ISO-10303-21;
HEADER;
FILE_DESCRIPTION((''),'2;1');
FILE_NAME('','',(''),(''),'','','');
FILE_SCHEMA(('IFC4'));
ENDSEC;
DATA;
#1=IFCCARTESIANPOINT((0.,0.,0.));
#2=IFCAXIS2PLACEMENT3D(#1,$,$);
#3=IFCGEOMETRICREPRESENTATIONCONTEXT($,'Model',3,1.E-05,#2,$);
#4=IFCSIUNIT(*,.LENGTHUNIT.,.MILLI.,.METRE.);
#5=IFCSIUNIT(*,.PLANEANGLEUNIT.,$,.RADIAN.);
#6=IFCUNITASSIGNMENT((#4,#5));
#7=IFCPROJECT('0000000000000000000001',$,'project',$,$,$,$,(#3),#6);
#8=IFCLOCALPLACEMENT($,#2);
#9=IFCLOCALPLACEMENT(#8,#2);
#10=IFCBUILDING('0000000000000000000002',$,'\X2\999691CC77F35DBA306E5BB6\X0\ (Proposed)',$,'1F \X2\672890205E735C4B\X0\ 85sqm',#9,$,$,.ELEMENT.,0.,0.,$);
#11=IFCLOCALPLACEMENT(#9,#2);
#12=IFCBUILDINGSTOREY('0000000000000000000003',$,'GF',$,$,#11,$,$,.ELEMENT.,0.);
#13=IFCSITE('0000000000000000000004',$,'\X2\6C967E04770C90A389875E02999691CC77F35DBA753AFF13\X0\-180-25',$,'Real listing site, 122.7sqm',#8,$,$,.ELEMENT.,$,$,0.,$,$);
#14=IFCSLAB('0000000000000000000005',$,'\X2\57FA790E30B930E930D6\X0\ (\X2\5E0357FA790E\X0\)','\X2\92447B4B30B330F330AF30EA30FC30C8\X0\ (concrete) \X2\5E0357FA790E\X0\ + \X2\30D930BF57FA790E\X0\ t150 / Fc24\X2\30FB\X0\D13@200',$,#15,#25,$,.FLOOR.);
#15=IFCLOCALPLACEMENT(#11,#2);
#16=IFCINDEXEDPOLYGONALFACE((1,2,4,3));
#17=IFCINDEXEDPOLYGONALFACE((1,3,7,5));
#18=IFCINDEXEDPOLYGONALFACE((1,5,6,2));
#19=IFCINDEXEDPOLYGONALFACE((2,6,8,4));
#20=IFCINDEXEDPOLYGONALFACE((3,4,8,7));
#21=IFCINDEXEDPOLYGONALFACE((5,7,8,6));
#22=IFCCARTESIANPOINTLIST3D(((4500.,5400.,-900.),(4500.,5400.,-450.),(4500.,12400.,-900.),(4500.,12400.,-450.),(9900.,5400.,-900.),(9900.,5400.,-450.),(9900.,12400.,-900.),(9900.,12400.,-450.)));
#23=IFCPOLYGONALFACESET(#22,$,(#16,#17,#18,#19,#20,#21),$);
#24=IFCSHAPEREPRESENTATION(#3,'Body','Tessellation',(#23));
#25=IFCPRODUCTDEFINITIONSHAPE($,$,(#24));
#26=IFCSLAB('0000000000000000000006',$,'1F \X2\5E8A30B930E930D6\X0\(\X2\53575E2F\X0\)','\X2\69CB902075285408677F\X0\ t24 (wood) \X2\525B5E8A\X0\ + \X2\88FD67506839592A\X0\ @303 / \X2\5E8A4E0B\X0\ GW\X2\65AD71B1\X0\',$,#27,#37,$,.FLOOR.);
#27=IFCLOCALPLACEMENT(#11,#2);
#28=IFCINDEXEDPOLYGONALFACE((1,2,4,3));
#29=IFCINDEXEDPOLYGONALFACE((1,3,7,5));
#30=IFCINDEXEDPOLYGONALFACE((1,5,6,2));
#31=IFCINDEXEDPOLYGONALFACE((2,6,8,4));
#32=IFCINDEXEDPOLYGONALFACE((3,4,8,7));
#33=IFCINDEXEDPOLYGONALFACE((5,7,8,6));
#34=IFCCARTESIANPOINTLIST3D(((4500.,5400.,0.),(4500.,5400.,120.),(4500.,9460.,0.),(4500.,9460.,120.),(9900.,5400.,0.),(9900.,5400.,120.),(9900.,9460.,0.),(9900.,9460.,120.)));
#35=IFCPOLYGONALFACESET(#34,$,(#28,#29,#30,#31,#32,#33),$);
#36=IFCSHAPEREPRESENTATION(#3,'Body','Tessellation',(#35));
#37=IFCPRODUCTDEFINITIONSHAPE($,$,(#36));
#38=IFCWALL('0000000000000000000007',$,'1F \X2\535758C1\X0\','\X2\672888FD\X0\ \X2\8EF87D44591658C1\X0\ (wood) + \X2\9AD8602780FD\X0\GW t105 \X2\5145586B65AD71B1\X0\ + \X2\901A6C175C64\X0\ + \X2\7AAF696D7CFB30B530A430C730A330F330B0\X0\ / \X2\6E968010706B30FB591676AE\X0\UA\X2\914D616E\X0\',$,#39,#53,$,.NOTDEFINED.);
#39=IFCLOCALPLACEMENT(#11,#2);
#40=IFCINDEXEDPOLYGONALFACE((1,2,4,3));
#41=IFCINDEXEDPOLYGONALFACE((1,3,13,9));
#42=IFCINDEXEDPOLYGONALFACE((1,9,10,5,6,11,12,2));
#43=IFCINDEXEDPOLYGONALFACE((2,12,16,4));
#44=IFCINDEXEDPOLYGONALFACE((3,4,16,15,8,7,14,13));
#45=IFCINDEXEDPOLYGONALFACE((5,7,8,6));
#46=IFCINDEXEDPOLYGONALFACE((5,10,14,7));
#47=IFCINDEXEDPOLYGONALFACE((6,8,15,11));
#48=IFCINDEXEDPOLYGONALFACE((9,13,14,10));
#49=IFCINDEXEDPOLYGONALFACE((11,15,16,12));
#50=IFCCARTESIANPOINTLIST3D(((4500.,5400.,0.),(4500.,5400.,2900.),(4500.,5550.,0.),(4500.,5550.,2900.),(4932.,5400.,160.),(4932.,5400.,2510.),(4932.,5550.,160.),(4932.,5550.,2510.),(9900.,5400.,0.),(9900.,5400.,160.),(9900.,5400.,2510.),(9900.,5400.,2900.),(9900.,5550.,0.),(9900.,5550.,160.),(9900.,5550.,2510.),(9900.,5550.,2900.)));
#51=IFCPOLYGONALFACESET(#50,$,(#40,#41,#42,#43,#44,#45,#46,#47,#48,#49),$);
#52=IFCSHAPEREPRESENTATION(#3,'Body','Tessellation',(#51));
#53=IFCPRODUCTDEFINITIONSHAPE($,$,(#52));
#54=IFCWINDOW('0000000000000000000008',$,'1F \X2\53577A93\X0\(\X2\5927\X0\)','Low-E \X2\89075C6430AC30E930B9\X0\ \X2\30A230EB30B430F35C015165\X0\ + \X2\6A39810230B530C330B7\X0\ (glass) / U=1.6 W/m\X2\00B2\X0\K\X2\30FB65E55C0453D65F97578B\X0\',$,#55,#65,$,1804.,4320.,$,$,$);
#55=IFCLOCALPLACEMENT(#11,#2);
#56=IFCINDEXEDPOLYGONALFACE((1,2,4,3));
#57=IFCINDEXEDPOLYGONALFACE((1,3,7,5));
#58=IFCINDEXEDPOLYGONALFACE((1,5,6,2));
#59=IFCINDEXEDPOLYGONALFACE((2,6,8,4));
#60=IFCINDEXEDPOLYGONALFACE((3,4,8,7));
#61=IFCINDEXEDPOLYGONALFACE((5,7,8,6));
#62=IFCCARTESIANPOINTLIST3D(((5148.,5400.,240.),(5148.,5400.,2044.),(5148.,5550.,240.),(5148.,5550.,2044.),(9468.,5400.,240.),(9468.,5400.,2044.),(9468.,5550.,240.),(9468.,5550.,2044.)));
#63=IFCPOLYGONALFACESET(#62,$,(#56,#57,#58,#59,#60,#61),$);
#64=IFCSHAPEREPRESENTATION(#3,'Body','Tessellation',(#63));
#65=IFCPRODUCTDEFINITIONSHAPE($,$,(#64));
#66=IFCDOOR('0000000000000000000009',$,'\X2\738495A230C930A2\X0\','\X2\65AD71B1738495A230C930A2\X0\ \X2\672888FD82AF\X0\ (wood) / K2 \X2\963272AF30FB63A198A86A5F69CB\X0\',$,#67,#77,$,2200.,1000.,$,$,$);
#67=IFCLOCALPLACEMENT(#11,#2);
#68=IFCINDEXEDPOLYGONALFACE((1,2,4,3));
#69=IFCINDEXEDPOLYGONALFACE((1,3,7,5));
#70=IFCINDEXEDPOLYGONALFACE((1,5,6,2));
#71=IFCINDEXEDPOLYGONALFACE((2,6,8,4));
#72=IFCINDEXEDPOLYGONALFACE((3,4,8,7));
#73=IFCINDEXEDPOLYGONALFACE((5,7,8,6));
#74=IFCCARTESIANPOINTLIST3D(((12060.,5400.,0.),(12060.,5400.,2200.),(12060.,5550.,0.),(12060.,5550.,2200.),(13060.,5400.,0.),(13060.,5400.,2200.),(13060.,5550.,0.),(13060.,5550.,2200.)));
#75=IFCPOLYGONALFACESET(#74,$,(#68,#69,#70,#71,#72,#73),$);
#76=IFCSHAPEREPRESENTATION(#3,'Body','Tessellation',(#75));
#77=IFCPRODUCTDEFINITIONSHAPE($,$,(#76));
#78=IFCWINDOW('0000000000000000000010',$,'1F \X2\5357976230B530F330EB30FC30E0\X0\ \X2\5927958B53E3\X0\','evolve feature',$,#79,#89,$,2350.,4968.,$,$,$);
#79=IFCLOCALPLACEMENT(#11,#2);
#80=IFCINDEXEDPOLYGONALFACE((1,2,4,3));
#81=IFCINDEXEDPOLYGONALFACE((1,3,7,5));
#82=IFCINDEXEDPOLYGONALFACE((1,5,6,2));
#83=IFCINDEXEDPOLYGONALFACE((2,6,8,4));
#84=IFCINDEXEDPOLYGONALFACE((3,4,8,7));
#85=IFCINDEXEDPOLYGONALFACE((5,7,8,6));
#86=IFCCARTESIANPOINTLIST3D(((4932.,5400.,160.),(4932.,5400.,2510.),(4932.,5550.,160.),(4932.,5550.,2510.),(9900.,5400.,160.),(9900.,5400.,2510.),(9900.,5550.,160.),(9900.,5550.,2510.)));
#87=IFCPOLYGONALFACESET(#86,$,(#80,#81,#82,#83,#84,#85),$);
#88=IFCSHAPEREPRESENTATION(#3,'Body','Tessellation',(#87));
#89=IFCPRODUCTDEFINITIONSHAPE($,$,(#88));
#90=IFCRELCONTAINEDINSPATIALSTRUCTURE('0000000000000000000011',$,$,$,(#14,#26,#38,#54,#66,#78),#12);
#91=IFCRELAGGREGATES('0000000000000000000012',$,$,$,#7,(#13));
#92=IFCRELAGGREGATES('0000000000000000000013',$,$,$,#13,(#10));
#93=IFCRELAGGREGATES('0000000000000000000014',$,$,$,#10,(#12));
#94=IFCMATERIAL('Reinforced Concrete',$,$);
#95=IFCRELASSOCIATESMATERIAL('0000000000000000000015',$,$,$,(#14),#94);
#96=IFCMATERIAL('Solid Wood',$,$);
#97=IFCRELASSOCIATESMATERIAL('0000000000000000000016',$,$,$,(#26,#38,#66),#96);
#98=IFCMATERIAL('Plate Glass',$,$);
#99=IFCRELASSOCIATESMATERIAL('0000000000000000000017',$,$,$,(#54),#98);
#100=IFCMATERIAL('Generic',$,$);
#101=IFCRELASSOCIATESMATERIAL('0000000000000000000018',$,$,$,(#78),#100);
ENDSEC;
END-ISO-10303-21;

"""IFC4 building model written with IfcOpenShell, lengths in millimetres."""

from ifc_helpers import new_model, si_unit, frame, frame_2d, origin, place, context, project, spatial, rectangle, extrude, material, element, fill, save


model = new_model("IFC4")

# Units and contexts
model_context = context("Model", 3, precision=1e-05, world=origin())
ifc_project = project(units=[si_unit("LENGTHUNIT", "METRE", prefix="MILLI"), si_unit("PLANEANGLEUNIT", "RADIAN")], contexts=[model_context])

# Site, building, storey
site_placement = place(None, origin())
site = spatial("IfcSite", under=ifc_project, at=site_placement, Name="沖縄県那覇市首里石嶺町３-180-25", ObjectType="Real listing site, 122.7sqm", CompositionType="ELEMENT", RefElevation=0.0)
building_placement = place(site_placement, origin())
building = spatial("IfcBuilding", under=site, at=building_placement, Name="首里石嶺の家 (Proposed)", ObjectType="1F 木造平屋 85sqm", CompositionType="ELEMENT", ElevationOfRefHeight=0.0, ElevationOfTerrain=0.0)
storey_placement = place(building_placement, origin())
storey = spatial("IfcBuildingStorey", under=building, at=storey_placement, Name="GF", CompositionType="ELEMENT", Elevation=0.0)

# Slabs
ifc_material_1 = material(Name="Reinforced Concrete")
slab_1_placement = place(storey_placement, frame((2250.0, 2700.0, -450.0)))
element("IfcSlab", 1, at=slab_1_placement, inside=storey, material=ifc_material_1, Name="基礎スラブ (布基礎)", Description="鉄筋コンクリート (concrete) 布基礎 + ベタ基礎 t150 / Fc24・D13@200", PredefinedType="FLOOR", context=model_context, shape_type="SweptSolid", body=[
    extrude(rectangle(XDim=5400.0, YDim=7000.0, at=frame_2d((2700.0, 3500.0))), frame((2250.0, 2700.0, -450.0)), (0.0, 0.0, 1.0), 450.0),
])
ifc_material_2 = material(Name="Solid Wood")
slab_2_placement = place(storey_placement, frame((2250.0, 2700.0, 0.0)))
element("IfcSlab", 2, at=slab_2_placement, inside=storey, material=ifc_material_2, Name="1F 床スラブ(南帯)", Description="構造用合板 t24 (wood) 剛床 + 製材根太 @303 / 床下 GW断熱", PredefinedType="FLOOR", context=model_context, shape_type="SweptSolid", body=[
    extrude(rectangle(XDim=5400.0, YDim=4060.0, at=frame_2d((2700.0, 2030.0))), frame((2250.0, 2700.0, 0.0)), (0.0, 0.0, 1.0), 120.0),
])

# Wall, openings, windows, door
wall_1_placement = place(storey_placement, frame((2250.0, 2700.0, 0.0)))
wall_1 = element("IfcWall", 3, at=wall_1_placement, inside=storey, material=ifc_material_2, Name="1F 南壁", Description="木製 軸組外壁 (wood) + 高性能GW t105 充填断熱 + 通気層 + 窯業系サイディング / 準耐火・外皮UA配慮", PredefinedType="NOTDEFINED", context=model_context, shape_type="SweptSolid", body=[
    extrude(rectangle(XDim=5400.0, YDim=150.0, at=frame_2d((2700.0, 75.0))), frame((2250.0, 2700.0, 0.0)), (0.0, 0.0, 1.0), 2900.0),
])
opening_1_placement = place(storey_placement, frame((2574.0, 2700.0, 120.0)))
opening_1 = element("IfcOpeningElement", 4, at=opening_1_placement, cuts=wall_1, PredefinedType="NOTDEFINED", context=model_context, shape_type="SweptSolid", body=[
    extrude(rectangle(XDim=4320.0, YDim=150.0, at=frame_2d((2160.0, 75.0))), frame((2574.0, 2700.0, 120.0)), (0.0, 0.0, 1.0), 1804.0),
])
opening_2_placement = place(storey_placement, frame((6030.0, 2700.0, 0.0)))
opening_2 = element("IfcOpeningElement", 5, at=opening_2_placement, cuts=wall_1, PredefinedType="NOTDEFINED", context=model_context, shape_type="SweptSolid", body=[
    extrude(rectangle(XDim=1000.0, YDim=150.0, at=frame_2d((500.0, 75.0))), frame((6030.0, 2700.0, 0.0)), (0.0, 0.0, 1.0), 2200.0),
])
opening_3_placement = place(storey_placement, frame((2466.0, 2700.0, 80.0)))
opening_3 = element("IfcOpeningElement", 6, at=opening_3_placement, cuts=wall_1, PredefinedType="NOTDEFINED", context=model_context, shape_type="SweptSolid", body=[
    extrude(rectangle(XDim=4968.0, YDim=150.0, at=frame_2d((2484.0, 75.0))), frame((2466.0, 2700.0, 80.0)), (0.0, 0.0, 1.0), 2350.0),
])
ifc_material_3 = material(Name="Plate Glass")
window_1_placement = place(storey_placement, frame((2574.0, 2700.0, 120.0)))
window_1 = element("IfcWindow", 7, at=window_1_placement, inside=storey, material=ifc_material_3, Name="1F 南窓(大)", Description="Low-E 複層ガラス アルゴン封入 + 樹脂サッシ (glass) / U=1.6 W/m²K・日射取得型", OverallHeight=1804.0, OverallWidth=4320.0, context=model_context, shape_type="SweptSolid", body=[
    extrude(rectangle(XDim=4320.0, YDim=150.0, at=frame_2d((2160.0, 75.0))), frame((2574.0, 2700.0, 120.0)), (0.0, 0.0, 1.0), 1804.0),
])
fill(opening_1, window_1)
door_1_placement = place(storey_placement, frame((6030.0, 2700.0, 0.0)))
door_1 = element("IfcDoor", 8, at=door_1_placement, inside=storey, material=ifc_material_2, Name="玄関ドア", Description="断熱玄関ドア 木製芯 (wood) / K2 防犯・採風機構", OverallHeight=2200.0, OverallWidth=1000.0, context=model_context, shape_type="SweptSolid", body=[
    extrude(rectangle(XDim=1000.0, YDim=150.0, at=frame_2d((500.0, 75.0))), frame((6030.0, 2700.0, 0.0)), (0.0, 0.0, 1.0), 2200.0),
])
fill(opening_2, door_1)
ifc_material_4 = material(Name="Generic")
window_2_placement = place(storey_placement, frame((2466.0, 2700.0, 80.0)))
window_2 = element("IfcWindow", 9, at=window_2_placement, inside=storey, material=ifc_material_4, Name="1F 南面サンルーム 大開口", Description="evolve feature", OverallHeight=2350.0, OverallWidth=4968.0, context=model_context, shape_type="SweptSolid", body=[
    extrude(rectangle(XDim=4968.0, YDim=150.0, at=frame_2d((2484.0, 75.0))), frame((2466.0, 2700.0, 80.0)), (0.0, 0.0, 1.0), 2350.0),
])
fill(opening_3, window_2)

save(model, "model.ifc")
